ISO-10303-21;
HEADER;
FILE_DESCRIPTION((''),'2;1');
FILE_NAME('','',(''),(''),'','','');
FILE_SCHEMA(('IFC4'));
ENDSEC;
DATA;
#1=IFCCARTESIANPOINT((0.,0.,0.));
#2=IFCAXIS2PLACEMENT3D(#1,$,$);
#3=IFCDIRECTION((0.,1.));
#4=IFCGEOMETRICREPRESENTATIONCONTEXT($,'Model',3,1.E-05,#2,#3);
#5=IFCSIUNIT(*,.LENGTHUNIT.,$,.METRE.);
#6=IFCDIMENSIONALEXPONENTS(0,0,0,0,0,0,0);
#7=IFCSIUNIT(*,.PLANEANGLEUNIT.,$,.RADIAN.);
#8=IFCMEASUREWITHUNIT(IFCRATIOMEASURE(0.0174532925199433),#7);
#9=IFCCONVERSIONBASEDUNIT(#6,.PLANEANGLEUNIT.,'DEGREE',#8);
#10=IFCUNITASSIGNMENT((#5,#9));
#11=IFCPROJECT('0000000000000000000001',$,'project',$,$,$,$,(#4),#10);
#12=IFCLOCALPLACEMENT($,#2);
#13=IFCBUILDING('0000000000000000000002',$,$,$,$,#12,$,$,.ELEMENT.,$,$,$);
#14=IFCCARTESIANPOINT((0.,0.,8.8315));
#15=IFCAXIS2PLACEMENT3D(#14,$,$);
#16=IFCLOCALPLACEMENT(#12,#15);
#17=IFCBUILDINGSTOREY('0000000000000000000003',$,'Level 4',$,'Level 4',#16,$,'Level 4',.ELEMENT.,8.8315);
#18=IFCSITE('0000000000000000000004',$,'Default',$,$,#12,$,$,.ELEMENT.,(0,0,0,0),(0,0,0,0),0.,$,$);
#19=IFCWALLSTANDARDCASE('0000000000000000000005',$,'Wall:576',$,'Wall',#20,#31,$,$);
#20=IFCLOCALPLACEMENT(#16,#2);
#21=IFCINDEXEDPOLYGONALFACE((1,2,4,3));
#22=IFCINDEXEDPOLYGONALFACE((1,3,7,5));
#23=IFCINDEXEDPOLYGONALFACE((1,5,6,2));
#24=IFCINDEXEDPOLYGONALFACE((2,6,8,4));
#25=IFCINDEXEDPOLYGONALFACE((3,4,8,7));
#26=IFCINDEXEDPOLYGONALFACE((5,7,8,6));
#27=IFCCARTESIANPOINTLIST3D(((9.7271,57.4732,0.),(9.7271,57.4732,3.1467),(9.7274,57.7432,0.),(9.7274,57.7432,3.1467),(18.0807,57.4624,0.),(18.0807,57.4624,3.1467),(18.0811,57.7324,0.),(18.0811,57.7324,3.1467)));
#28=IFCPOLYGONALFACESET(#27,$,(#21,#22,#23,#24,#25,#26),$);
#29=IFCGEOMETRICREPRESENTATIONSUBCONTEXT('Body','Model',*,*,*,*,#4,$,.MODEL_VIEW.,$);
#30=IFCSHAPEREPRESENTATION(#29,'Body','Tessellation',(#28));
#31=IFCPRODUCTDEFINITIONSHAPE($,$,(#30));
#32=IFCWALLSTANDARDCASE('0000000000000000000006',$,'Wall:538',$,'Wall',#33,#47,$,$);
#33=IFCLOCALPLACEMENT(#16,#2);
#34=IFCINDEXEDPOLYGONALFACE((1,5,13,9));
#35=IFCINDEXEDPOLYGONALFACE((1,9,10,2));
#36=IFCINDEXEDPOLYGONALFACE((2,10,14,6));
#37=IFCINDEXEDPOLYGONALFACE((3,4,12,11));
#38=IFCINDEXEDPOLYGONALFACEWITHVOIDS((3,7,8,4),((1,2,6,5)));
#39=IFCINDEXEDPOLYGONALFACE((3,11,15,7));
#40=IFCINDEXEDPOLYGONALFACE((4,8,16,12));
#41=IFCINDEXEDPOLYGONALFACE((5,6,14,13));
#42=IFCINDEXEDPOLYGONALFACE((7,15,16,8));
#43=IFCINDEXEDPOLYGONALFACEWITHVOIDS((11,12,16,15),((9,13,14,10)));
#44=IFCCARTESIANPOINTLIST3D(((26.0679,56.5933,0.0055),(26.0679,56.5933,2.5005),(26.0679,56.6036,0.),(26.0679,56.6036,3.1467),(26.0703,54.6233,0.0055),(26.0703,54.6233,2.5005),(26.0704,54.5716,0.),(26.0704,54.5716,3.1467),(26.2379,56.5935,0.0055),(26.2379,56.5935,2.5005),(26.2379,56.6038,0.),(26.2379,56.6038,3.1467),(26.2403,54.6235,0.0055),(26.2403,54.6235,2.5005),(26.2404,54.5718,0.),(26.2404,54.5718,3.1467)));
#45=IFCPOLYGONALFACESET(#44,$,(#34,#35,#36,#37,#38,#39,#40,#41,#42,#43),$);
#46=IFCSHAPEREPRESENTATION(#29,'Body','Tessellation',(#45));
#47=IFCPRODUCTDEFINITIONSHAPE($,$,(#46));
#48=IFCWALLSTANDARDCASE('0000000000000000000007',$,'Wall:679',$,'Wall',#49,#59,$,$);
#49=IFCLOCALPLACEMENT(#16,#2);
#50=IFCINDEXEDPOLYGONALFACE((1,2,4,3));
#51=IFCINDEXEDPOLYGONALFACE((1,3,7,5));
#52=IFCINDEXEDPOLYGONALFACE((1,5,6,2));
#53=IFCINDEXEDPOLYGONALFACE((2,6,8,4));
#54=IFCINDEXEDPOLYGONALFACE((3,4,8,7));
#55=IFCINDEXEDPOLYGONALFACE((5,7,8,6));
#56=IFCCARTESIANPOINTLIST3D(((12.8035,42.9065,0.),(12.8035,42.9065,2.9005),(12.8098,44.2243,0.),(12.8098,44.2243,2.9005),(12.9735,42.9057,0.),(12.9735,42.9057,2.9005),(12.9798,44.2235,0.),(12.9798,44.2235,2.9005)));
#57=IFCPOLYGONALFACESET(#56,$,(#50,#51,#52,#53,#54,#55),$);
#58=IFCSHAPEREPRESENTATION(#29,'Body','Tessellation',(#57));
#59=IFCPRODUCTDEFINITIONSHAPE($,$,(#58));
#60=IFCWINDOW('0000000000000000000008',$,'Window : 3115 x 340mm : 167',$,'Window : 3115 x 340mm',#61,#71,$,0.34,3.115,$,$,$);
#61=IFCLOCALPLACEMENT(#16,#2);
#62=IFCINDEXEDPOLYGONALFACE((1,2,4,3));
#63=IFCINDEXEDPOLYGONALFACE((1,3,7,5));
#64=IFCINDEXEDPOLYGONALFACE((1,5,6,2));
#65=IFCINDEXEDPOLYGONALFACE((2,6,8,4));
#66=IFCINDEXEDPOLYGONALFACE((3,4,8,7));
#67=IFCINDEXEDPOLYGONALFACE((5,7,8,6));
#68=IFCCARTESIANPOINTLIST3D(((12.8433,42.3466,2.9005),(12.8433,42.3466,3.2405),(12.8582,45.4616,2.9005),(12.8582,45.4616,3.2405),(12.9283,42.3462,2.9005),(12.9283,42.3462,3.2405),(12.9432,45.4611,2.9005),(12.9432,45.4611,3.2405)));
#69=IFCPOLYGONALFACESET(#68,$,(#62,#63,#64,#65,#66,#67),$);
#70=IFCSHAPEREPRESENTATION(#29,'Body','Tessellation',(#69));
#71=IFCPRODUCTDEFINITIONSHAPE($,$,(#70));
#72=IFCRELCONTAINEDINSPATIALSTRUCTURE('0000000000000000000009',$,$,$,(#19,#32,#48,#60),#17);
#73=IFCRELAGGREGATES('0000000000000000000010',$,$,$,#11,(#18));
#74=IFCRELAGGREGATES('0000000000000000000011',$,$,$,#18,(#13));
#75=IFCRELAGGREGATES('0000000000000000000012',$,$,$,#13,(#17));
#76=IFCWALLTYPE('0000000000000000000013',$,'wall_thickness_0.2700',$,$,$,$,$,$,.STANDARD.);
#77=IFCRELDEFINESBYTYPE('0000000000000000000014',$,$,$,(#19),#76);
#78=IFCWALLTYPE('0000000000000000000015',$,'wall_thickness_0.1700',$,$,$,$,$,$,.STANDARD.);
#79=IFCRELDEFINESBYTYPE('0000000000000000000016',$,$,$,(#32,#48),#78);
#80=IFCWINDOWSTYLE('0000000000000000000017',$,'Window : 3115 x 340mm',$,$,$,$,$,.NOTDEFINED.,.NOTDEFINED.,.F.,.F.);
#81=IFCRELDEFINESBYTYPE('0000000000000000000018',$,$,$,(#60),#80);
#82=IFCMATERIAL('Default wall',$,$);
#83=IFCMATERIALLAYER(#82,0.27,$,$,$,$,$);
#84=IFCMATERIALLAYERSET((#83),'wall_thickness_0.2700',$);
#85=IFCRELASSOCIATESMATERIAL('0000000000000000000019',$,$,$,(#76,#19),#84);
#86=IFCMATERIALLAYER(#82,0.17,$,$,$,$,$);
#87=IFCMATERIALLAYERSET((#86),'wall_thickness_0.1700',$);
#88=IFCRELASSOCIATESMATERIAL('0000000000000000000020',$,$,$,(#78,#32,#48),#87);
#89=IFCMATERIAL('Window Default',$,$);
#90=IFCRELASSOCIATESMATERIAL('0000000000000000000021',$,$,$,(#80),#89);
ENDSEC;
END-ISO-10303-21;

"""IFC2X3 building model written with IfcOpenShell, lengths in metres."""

from ifc_helpers import new_model, entity, si_unit, converted_unit, direction, frame, frame_2d, origin, origin_2d_with_axis, place, context, subcontext, project, spatial, polyline, rectangle, outline, extrude, source, transform, mapped, material, layer, layer_set, layer_usage, type_object, type_shapes, element, fill, save


model = new_model("IFC2X3")

# Units and contexts
model_context = context("Model", 3, precision=1e-05, world=origin(), true_north=direction((0.0, 1.0)))
body_context = subcontext(model_context, "Body", "Model", "MODEL_VIEW")
ifc_project = project(units=[si_unit("LENGTHUNIT", "METRE"), converted_unit("PLANEANGLEUNIT", "DEGREE", entity("IfcRatioMeasure", 0.0174532925199433), si_unit("PLANEANGLEUNIT", "RADIAN"), dimensions=[0, 0, 0, 0, 0, 0, 0])], contexts=[model_context])

# Site, building, storey
placement_1 = place(None, origin())
site = spatial("IfcSite", under=ifc_project, at=placement_1, Name="Default", CompositionType="ELEMENT", RefLatitude=(0, 0, 0, 0), RefLongitude=(0, 0, 0, 0), RefElevation=0.0)
building = spatial("IfcBuilding", under=site, at=placement_1, CompositionType="ELEMENT")
storey_placement = place(placement_1, frame((0.0, 0.0, 8.8315)))
storey = spatial("IfcBuildingStorey", under=building, at=storey_placement, Name="Level 4", ObjectType="Level 4", LongName="Level 4", CompositionType="ELEMENT", Elevation=8.8315)

# Shared definitions
ifc_material_1 = material(Name="Default wall")

# Shared definitions
ifc_material_2 = material(Name="Window Default")

# Wall
ifc_layer_1 = layer(ifc_material_1, 0.27)
ifc_layer_set_1 = layer_set([ifc_layer_1], Name="wall_thickness_0.2700")
ifc_layer_usage_1 = layer_usage(ifc_layer_set_1, "AXIS2", "POSITIVE", -0.135)
wall_type_1 = type_object("IfcWallType", Name="wall_thickness_0.2700", PredefinedType="STANDARD", material=ifc_layer_set_1)
wall_1_placement = place(storey_placement, frame((9.7273, 57.6082, 0.0), z_axis=(0.0, 0.0, 1.0), x_axis=(0.999999, -0.001299, 0.0)))
element("IfcWallStandardCase", 1, at=wall_1_placement, inside=storey, type_object=wall_type_1, material=ifc_layer_usage_1, Name="Wall:576", ObjectType="Wall", context=body_context, shape_type="SweptSolid", body=[
    extrude(outline(polyline([(8.3536, -0.135), (8.3536, 0.135), (0.0, 0.135), (0.0, -0.135), (8.3536, -0.135)])), origin(), (0.0, 0.0, 1.0), 3.1467),
])

# Wall, opening
ifc_layer_2 = layer(ifc_material_1, 0.17)
ifc_layer_set_2 = layer_set([ifc_layer_2], Name="wall_thickness_0.1700")
ifc_layer_usage_2 = layer_usage(ifc_layer_set_2, "AXIS2", "POSITIVE", -0.085)
wall_type_2 = type_object("IfcWallType", Name="wall_thickness_0.1700", PredefinedType="STANDARD", material=ifc_layer_set_2)
wall_2_placement = place(storey_placement, frame((26.1529, 56.6037, 0.0), z_axis=(0.0, 0.0, 1.0), x_axis=(0.001206, -0.999999, 0.0)))
wall_2 = element("IfcWallStandardCase", 2, at=wall_2_placement, inside=storey, type_object=wall_type_2, material=ifc_layer_usage_2, Name="Wall:538", ObjectType="Wall", context=body_context, shape_type="SweptSolid", body=[
    extrude(outline(polyline([(2.032, -0.085), (2.032, 0.085), (0.0, 0.085), (0.0, -0.085), (2.032, -0.085)])), origin(), (0.0, 0.0, 1.0), 3.1467),
])
opening_1_placement = place(wall_2_placement, frame((0.0103, -0.085, 0.0055)))
element("IfcOpeningElement", 3, at=opening_1_placement, cuts=wall_2, ObjectType="Opening", context=body_context, shape_type="SweptSolid", body=[
    extrude(rectangle(XDim=1.97, YDim=2.495, at=frame_2d((1.2475, 0.985), x_axis=(0.0, 1.0))), frame((0.0, 0.0, 0.0), z_axis=(0.0, 1.0, 0.0), x_axis=(0.0, 0.0, 1.0)), (0.0, 0.0, 1.0), 0.17),
])

# Wall, opening, window
wall_3_placement = place(storey_placement, frame((12.8948, 44.2239, 0.0), z_axis=(0.0, 0.0, 1.0), x_axis=(-0.004802, -0.999988, 0.0)))
wall_3 = element("IfcWallStandardCase", 4, at=wall_3_placement, inside=storey, type_object=wall_type_2, material=ifc_layer_usage_2, Name="Wall:679", ObjectType="Wall", context=body_context, shape_type="SweptSolid", body=[
    extrude(outline(polyline([(1.3178, -0.085), (1.3178, 0.085), (0.0, 0.085), (0.0, -0.085), (1.3178, -0.085)])), origin(), (0.0, 0.0, 1.0), 3.1467),
])
opening_2_placement = place(wall_3_placement, frame((-1.2375, -0.085, 2.9005)))
opening_2 = element("IfcOpeningElement", 5, at=opening_2_placement, cuts=wall_3, ObjectType="Opening", context=body_context, shape_type="SweptSolid", body=[
    extrude(rectangle(XDim=3.115, YDim=0.34, at=frame_2d((0.17, 1.5575), x_axis=(0.0, 1.0))), frame((0.0, 0.0, 0.0), z_axis=(0.0, 1.0, 0.0), x_axis=(0.0, 0.0, 1.0)), (0.0, 0.0, 1.0), 0.17),
])
window_style_1 = type_object("IfcWindowStyle", Name="Window : 3115 x 340mm", ConstructionType="NOTDEFINED", OperationType="NOTDEFINED", ParameterTakesPrecedence=False, Sizeable=False, material=ifc_material_2)
shared_shape_1 = source(origin(), body_context, "Body", "SweptSolid", [
    extrude(rectangle(XDim=0.085, YDim=3.115, at=origin_2d_with_axis()), frame((1.5575, 0.085, 0.0), z_axis=(0.0, 0.0, 1.0), x_axis=(0.0, 1.0, 0.0)), (0.0, 0.0, 1.0), 0.34),
])
type_shapes(window_style_1, [shared_shape_1])
window_1_placement = place(opening_2_placement, origin())
window_1 = element("IfcWindow", 6, at=window_1_placement, inside=storey, type_object=window_style_1, Name="Window : 3115 x 340mm : 167", ObjectType="Window : 3115 x 340mm", OverallHeight=0.34, OverallWidth=3.115, context=body_context, shape_type="MappedRepresentation", body=[
    mapped(shared_shape_1, transform((0.0, 0.0, 0.0), scale=1.0)),
])
fill(opening_2, window_1)

save(model, "model.ifc")
